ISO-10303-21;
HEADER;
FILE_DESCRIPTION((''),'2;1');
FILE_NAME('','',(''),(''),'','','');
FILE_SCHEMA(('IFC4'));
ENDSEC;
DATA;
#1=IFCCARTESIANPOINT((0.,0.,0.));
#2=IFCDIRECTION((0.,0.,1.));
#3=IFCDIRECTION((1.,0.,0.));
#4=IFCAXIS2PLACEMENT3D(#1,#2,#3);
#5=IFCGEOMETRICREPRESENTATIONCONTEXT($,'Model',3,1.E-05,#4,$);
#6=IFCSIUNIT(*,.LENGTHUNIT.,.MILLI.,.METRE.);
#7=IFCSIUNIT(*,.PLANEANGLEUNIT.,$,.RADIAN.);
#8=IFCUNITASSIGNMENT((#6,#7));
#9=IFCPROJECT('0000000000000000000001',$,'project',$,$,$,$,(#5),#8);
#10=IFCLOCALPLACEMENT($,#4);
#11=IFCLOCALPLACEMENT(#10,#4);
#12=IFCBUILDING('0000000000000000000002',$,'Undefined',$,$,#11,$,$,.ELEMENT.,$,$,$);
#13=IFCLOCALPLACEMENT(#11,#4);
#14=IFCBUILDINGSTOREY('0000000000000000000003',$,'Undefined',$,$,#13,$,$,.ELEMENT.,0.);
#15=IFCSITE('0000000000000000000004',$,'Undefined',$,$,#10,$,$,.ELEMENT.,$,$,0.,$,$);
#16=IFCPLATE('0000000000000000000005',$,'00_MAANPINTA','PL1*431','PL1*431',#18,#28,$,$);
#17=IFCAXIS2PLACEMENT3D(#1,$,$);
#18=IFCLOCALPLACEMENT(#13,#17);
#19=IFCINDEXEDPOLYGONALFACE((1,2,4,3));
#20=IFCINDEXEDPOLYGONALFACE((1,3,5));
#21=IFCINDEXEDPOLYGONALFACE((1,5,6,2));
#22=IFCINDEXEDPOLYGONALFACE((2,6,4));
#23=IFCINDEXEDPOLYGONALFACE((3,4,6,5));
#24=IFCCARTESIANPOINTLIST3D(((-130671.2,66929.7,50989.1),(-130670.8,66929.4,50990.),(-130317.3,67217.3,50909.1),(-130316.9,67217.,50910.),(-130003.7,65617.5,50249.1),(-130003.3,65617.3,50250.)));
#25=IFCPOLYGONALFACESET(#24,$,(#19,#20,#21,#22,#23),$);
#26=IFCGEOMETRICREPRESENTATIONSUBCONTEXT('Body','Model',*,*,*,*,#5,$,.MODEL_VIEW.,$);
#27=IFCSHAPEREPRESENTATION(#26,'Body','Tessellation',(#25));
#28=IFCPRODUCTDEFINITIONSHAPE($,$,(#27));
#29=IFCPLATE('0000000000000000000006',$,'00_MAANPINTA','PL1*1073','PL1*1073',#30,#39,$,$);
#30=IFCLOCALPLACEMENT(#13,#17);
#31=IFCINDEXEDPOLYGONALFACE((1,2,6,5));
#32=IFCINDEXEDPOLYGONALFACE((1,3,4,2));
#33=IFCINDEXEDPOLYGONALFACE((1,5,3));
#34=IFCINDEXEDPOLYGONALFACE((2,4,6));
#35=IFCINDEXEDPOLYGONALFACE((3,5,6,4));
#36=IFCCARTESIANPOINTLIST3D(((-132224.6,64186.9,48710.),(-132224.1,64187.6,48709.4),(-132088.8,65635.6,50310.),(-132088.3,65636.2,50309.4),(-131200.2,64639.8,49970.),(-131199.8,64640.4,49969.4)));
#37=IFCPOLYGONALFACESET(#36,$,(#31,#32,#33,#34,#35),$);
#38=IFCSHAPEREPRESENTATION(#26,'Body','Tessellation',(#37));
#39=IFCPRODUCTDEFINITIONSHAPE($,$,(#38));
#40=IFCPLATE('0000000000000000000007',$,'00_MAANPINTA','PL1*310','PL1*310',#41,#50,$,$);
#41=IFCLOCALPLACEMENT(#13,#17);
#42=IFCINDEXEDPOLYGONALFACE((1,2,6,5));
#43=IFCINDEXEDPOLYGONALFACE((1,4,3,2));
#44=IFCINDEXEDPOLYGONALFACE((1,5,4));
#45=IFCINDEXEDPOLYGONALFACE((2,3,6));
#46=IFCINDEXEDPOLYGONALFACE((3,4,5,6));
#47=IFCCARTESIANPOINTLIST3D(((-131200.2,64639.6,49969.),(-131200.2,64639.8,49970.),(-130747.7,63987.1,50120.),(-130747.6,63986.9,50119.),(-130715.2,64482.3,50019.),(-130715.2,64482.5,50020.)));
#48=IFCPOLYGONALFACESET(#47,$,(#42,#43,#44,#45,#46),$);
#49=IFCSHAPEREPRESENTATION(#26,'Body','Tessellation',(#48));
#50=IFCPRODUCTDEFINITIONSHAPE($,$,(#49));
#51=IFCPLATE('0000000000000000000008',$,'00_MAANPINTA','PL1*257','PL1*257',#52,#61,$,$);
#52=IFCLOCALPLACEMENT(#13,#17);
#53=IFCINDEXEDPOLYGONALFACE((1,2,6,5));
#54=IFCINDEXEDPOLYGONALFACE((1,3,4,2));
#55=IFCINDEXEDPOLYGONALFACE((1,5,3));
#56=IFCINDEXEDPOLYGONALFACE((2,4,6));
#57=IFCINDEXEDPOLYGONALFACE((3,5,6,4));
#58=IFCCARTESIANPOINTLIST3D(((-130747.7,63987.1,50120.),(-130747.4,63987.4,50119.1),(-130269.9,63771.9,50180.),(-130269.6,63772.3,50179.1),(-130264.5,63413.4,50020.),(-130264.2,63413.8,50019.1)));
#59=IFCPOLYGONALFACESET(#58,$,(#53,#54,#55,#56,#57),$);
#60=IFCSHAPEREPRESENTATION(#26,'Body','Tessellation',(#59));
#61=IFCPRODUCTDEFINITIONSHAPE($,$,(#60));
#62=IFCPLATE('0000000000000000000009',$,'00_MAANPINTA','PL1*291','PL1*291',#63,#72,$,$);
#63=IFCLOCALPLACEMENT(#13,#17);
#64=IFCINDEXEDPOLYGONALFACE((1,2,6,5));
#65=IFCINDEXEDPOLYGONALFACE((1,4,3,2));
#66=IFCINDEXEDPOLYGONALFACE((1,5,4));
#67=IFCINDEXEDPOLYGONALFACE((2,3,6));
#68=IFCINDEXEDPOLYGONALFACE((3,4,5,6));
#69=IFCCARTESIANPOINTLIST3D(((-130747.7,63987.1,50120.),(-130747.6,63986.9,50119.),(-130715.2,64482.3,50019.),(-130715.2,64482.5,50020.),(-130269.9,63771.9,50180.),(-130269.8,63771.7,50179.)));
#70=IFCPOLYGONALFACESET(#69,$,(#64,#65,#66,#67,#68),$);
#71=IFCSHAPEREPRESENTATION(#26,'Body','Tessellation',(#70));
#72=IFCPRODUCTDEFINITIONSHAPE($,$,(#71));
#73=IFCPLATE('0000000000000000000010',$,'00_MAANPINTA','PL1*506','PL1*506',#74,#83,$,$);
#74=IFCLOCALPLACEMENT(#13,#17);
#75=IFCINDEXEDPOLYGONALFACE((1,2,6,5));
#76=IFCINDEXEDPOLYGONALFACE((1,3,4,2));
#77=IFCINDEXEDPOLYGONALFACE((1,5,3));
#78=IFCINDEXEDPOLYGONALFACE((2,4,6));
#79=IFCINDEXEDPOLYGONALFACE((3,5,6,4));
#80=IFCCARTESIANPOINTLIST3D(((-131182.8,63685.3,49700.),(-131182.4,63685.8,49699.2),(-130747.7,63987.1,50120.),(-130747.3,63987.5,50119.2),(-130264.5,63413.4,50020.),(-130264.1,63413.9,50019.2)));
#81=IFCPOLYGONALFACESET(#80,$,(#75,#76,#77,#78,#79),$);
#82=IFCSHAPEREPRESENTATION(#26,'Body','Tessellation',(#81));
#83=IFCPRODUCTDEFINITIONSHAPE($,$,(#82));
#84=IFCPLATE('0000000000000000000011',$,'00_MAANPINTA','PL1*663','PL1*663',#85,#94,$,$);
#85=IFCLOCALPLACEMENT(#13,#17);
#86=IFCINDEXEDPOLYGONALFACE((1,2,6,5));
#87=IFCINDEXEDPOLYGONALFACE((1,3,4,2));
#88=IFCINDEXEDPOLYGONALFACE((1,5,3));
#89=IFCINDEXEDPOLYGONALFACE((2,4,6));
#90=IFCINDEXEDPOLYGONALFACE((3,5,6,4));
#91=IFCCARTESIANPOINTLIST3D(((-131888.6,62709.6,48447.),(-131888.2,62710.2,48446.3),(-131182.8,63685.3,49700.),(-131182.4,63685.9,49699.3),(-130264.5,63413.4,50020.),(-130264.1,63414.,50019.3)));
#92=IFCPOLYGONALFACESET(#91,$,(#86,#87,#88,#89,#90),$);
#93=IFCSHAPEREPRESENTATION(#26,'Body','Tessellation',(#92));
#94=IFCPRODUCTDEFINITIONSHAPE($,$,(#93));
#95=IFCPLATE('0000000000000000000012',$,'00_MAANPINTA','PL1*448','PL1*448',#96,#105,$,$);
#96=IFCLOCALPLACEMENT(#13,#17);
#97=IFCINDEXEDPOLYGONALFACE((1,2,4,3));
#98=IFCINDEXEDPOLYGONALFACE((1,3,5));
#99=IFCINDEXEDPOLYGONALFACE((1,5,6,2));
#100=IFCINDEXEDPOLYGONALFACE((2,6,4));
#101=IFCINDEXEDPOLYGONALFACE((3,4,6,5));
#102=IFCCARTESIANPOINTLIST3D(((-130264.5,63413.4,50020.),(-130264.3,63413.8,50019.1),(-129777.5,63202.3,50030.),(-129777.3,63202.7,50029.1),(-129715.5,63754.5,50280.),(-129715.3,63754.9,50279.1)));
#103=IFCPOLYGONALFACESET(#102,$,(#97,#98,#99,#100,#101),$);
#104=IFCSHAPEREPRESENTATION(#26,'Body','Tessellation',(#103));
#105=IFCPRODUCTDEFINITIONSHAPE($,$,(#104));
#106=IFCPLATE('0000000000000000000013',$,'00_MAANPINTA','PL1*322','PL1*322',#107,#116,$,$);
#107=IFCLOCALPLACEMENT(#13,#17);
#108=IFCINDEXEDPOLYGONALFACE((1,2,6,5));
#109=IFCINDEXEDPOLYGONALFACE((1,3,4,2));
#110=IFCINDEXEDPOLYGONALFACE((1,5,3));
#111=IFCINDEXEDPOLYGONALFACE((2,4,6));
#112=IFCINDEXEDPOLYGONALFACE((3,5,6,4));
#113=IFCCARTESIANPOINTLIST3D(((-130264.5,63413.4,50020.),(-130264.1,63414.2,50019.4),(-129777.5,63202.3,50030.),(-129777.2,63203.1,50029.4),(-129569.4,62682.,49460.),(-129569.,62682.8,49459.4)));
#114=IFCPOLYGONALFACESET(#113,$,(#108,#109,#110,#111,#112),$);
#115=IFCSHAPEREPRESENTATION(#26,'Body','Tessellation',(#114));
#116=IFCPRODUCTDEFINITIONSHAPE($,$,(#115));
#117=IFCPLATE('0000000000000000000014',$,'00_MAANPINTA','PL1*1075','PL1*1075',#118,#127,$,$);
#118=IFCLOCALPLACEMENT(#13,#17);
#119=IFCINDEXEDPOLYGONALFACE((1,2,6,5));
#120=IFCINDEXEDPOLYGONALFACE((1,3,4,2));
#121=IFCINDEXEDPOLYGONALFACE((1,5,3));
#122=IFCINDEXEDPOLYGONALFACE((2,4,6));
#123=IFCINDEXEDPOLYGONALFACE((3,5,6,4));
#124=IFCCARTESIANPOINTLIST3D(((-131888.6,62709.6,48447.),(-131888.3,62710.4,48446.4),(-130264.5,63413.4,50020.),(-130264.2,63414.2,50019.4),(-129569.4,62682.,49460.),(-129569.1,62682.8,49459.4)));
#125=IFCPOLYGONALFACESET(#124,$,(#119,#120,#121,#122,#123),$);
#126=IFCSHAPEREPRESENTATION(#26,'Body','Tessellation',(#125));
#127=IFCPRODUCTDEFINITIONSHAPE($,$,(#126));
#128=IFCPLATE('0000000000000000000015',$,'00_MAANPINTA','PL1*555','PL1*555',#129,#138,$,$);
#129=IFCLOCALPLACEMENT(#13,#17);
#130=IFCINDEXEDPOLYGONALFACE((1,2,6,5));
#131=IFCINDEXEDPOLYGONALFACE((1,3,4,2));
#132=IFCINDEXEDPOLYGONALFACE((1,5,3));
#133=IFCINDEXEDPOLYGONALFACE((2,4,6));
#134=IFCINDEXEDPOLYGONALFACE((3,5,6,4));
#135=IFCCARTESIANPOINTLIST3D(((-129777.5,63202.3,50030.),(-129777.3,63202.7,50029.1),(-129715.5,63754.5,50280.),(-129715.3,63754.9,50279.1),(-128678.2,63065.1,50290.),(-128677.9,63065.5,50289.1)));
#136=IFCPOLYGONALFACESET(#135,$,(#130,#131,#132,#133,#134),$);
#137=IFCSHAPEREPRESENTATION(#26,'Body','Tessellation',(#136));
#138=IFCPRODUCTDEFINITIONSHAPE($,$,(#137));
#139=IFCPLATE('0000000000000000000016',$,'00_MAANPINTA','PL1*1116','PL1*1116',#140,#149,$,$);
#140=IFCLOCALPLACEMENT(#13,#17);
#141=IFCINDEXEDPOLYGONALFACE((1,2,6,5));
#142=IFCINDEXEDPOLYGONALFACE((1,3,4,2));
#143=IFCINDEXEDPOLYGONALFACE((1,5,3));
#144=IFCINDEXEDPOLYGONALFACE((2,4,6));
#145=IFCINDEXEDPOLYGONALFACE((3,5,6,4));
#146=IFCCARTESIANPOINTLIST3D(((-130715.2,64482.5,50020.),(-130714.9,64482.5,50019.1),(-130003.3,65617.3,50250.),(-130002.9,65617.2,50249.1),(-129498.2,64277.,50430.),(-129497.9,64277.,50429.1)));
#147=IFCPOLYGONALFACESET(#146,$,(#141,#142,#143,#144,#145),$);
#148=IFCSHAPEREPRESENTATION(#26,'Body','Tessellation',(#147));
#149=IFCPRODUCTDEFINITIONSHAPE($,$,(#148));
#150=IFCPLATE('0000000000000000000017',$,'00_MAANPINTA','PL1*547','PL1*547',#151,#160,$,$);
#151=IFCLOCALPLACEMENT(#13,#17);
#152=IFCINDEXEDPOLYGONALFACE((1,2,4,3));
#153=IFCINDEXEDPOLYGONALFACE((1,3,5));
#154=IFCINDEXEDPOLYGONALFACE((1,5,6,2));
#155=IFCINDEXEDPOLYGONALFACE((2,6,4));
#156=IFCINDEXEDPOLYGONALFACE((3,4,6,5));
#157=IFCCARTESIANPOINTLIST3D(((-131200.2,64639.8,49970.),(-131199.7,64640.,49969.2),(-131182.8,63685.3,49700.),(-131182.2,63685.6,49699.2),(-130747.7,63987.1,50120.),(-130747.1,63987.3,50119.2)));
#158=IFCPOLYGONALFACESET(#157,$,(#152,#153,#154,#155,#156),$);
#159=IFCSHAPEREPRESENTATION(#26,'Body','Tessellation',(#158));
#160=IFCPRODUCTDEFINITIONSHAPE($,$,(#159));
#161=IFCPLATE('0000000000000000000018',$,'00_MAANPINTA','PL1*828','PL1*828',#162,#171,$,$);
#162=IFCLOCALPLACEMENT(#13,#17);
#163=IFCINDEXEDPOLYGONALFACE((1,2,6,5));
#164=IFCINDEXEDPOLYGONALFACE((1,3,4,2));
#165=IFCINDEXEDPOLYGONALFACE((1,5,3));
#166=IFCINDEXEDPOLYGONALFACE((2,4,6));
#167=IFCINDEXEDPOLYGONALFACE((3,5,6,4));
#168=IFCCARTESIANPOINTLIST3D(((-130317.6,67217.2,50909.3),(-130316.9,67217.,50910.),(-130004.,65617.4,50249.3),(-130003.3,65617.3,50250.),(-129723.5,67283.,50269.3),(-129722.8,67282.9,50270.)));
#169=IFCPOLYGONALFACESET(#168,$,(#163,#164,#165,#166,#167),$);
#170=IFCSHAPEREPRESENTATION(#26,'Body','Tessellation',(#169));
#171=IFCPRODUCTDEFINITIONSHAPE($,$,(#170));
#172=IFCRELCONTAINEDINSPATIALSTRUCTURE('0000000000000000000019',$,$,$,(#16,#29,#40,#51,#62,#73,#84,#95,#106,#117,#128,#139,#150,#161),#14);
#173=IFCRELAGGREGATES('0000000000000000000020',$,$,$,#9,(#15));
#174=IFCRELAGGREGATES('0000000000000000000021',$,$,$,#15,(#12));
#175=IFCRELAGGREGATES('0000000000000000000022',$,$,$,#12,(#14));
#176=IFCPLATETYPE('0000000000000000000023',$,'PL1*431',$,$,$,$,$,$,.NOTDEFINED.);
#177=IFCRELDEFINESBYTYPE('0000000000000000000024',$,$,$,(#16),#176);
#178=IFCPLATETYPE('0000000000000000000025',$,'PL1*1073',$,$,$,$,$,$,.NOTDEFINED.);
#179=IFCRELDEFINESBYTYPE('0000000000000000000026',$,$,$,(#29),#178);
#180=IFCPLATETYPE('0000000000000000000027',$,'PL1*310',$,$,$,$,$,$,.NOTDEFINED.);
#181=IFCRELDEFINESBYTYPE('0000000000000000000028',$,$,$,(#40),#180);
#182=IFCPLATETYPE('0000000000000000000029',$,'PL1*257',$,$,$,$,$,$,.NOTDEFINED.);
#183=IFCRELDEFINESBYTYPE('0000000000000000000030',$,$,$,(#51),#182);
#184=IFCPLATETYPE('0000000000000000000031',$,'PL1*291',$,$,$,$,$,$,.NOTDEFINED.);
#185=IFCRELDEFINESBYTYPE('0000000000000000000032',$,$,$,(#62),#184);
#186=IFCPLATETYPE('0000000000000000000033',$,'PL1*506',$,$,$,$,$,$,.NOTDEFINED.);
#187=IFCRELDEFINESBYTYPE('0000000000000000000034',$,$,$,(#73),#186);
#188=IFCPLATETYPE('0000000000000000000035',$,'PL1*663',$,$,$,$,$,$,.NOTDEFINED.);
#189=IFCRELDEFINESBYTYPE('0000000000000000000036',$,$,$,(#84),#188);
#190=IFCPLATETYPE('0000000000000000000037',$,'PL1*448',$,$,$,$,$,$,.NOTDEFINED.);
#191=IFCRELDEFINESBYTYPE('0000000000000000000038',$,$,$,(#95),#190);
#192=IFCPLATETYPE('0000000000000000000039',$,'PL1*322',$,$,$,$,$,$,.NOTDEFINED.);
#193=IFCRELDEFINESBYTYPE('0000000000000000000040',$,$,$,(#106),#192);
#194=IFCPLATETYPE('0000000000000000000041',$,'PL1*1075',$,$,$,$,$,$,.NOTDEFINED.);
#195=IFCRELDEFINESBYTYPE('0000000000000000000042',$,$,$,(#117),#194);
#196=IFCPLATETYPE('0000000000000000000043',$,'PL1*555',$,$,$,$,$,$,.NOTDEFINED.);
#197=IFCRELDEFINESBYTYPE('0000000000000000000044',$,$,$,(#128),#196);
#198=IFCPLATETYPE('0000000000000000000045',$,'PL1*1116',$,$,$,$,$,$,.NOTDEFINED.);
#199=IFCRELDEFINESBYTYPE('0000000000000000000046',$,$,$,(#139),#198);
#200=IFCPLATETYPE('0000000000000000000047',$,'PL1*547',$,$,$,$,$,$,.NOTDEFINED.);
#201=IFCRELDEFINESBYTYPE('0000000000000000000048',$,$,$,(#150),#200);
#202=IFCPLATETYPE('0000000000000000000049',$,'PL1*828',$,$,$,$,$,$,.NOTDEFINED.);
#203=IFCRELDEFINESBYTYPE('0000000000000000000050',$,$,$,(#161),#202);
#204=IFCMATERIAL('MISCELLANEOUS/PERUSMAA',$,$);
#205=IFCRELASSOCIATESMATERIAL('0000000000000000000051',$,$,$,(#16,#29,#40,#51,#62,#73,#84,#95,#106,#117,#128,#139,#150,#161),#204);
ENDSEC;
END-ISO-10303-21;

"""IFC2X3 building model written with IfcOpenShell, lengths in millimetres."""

from ifc_helpers import new_model, si_unit, frame, origin_with_axes, place, context, subcontext, project, spatial, polyline, outline, extrude, material, type_object, element, save


model = new_model("IFC2X3")

# Units and contexts
model_context = context("Model", 3, precision=1e-05, world=origin_with_axes())
body_context = subcontext(model_context, "Body", "Model", "MODEL_VIEW")
ifc_project = project(units=[si_unit("LENGTHUNIT", "METRE", prefix="MILLI"), si_unit("PLANEANGLEUNIT", "RADIAN")], contexts=[model_context])

# Site, building, storey
site_placement = place(None, origin_with_axes())
site = spatial("IfcSite", under=ifc_project, at=site_placement, Name="Undefined", CompositionType="ELEMENT", RefElevation=0.0)
building_placement = place(site_placement, origin_with_axes())
building = spatial("IfcBuilding", under=site, at=building_placement, Name="Undefined", CompositionType="ELEMENT")
storey_placement = place(building_placement, origin_with_axes())
storey = spatial("IfcBuildingStorey", under=building, at=storey_placement, Name="Undefined", CompositionType="ELEMENT", Elevation=0.0)

# Plates
ifc_material = material(Name="MISCELLANEOUS/PERUSMAA")
plate_type_1 = type_object("IfcPlateType", Name="PL1*431", PredefinedType="NOTDEFINED")
plate_1_placement = place(storey_placement, frame((-130671.0, 66929.5, 50989.6), z_axis=(-0.419029, 0.27486, -0.865371), x_axis=(0.76432, 0.62126, -0.172774)))
element("IfcPlate", 1, at=plate_1_placement, inside=storey, type_object=plate_type_1, material=ifc_material, Name="00_MAANPINTA", Description="PL1*431", ObjectType="PL1*431", context=body_context, shape_type="SweptSolid", body=[
    extrude(outline(polyline([(0.0, 0.0), (463.0, 0.0), (-177.1, 1638.2), (0.0, 0.0)])), frame((0.0, 0.0, -0.5), z_axis=(0.0, 0.0, 1.0), x_axis=(1.0, 0.0, 0.0)), (0.0, 0.0, 1.0), 1.0),
])
plate_type_2 = type_object("IfcPlateType", Name="PL1*1073", PredefinedType="NOTDEFINED")
plate_2_placement = place(storey_placement, frame((-131200.0, 64640.1, 49969.7), z_axis=(0.474139, 0.632273, -0.612717), x_axis=(-0.607632, -0.268631, -0.747409)))
element("IfcPlate", 2, at=plate_2_placement, inside=storey, type_object=plate_type_2, material=ifc_material, Name="00_MAANPINTA", Description="PL1*1073", ObjectType="PL1*1073", context=body_context, shape_type="SweptSolid", body=[
    extrude(outline(polyline([(0.0, 0.0), (1685.8, 0.0), (18.3, 1377.0), (0.0, 0.0)])), frame((0.0, 0.0, -0.5), z_axis=(0.0, 0.0, 1.0), x_axis=(1.0, 0.0, 0.0)), (0.0, 0.0, 1.0), 1.0),
])
plate_type_3 = type_object("IfcPlateType", Name="PL1*310", PredefinedType="NOTDEFINED")
plate_3_placement = place(storey_placement, frame((-131200.2, 64639.7, 49969.5), z_axis=(0.036068, -0.199997, -0.979132), x_axis=(0.946677, -0.307049, 0.09759)))
element("IfcPlate", 3, at=plate_3_placement, inside=storey, type_object=plate_type_3, material=ifc_material, Name="00_MAANPINTA", Description="PL1*310", ObjectType="PL1*310", context=body_context, shape_type="SweptSolid", body=[
    extrude(outline(polyline([(0.0, 0.0), (512.3, 0.0), (643.5, 489.2), (0.0, 0.0)])), frame((0.0, 0.0, -0.5), z_axis=(0.0, 0.0, 1.0), x_axis=(1.0, 0.0, 0.0)), (0.0, 0.0, 1.0), 1.0),
])
plate_type_4 = type_object("IfcPlateType", Name="PL1*257", PredefinedType="NOTDEFINED")
plate_4_placement = place(storey_placement, frame((-130747.5, 63987.3, 50119.6), z_axis=(0.287099, 0.394059, -0.873093), x_axis=(0.905886, -0.407959, 0.113756)))
element("IfcPlate", 4, at=plate_4_placement, inside=storey, type_object=plate_type_4, material=ifc_material, Name="00_MAANPINTA", Description="PL1*257", ObjectType="PL1*257", context=body_context, shape_type="SweptSolid", body=[
    extrude(outline(polyline([(0.0, 0.0), (527.4, 0.0), (660.4, 369.4), (0.0, 0.0)])), frame((0.0, 0.0, -0.5), z_axis=(0.0, 0.0, 1.0), x_axis=(1.0, 0.0, 0.0)), (0.0, 0.0, 1.0), 1.0),
])
plate_type_5 = type_object("IfcPlateType", Name="PL1*291", PredefinedType="NOTDEFINED")
plate_5_placement = place(storey_placement, frame((-130715.2, 64482.4, 50019.5), z_axis=(0.032982, -0.199824, -0.979277), x_axis=(0.521645, -0.832325, 0.187407)))
element("IfcPlate", 5, at=plate_5_placement, inside=storey, type_object=plate_type_5, material=ifc_material, Name="00_MAANPINTA", Description="PL1*291", ObjectType="PL1*291", context=body_context, shape_type="SweptSolid", body=[
    extrude(outline(polyline([(0.0, 0.0), (853.8, 0.0), (414.2, 291.5), (0.0, 0.0)])), frame((0.0, 0.0, -0.5), z_axis=(0.0, 0.0, 1.0), x_axis=(1.0, 0.0, 0.0)), (0.0, 0.0, 1.0), 1.0),
])
plate_type_6 = type_object("IfcPlateType", Name="PL1*506", PredefinedType="NOTDEFINED")
plate_6_placement = place(storey_placement, frame((-130264.3, 63413.7, 50019.6), z_axis=(0.412116, 0.48196, -0.773223), x_axis=(-0.909442, 0.269246, -0.316894)))
element("IfcPlate", 6, at=plate_6_placement, inside=storey, type_object=plate_type_6, material=ifc_material, Name="00_MAANPINTA", Description="PL1*506", ObjectType="PL1*506", context=body_context, shape_type="SweptSolid", body=[
    extrude(outline(polyline([(0.0, 0.0), (1009.8, 0.0), (562.2, 506.4), (0.0, 0.0)])), frame((0.0, 0.0, -0.5), z_axis=(0.0, 0.0, 1.0), x_axis=(1.0, 0.0, 0.0)), (0.0, 0.0, 1.0), 1.0),
])
plate_type_7 = type_object("IfcPlateType", Name="PL1*663", PredefinedType="NOTDEFINED")
plate_7_placement = place(storey_placement, frame((-131888.4, 62709.9, 48446.7), z_axis=(0.415831, 0.589049, -0.692897), x_axis=(0.406112, 0.561438, 0.721014)))
element("IfcPlate", 7, at=plate_7_placement, inside=storey, type_object=plate_type_7, material=ifc_material, Name="00_MAANPINTA", Description="PL1*663", ObjectType="PL1*663", context=body_context, shape_type="SweptSolid", body=[
    extrude(outline(polyline([(0.0, 0.0), (1737.8, 0.0), (2188.9, 903.5), (0.0, 0.0)])), frame((0.0, 0.0, -0.5), z_axis=(0.0, 0.0, 1.0), x_axis=(1.0, 0.0, 0.0)), (0.0, 0.0, 1.0), 1.0),
])
plate_type_8 = type_object("IfcPlateType", Name="PL1*448", PredefinedType="NOTDEFINED")
plate_8_placement = place(storey_placement, frame((-130264.4, 63413.6, 50019.5), z_axis=(0.186638, 0.387703, -0.902692), x_axis=(0.788014, 0.489632, 0.373223)))
element("IfcPlate", 8, at=plate_8_placement, inside=storey, type_object=plate_type_8, material=ifc_material, Name="00_MAANPINTA", Description="PL1*448", ObjectType="PL1*448", context=body_context, shape_type="SweptSolid", body=[
    extrude(outline(polyline([(0.0, 0.0), (696.6, 0.0), (284.1, 448.4), (0.0, 0.0)])), frame((0.0, 0.0, -0.5), z_axis=(0.0, 0.0, 1.0), x_axis=(1.0, 0.0, 0.0)), (0.0, 0.0, 1.0), 1.0),
])
plate_type_9 = type_object("IfcPlateType", Name="PL1*322", PredefinedType="NOTDEFINED")
plate_9_placement = place(storey_placement, frame((-129569.2, 62682.4, 49459.7), z_axis=(0.338196, 0.753291, -0.564071), x_axis=(-0.602337, 0.633799, 0.485272)))
element("IfcPlate", 9, at=plate_9_placement, inside=storey, type_object=plate_type_9, material=ifc_material, Name="00_MAANPINTA", Description="PL1*322", ObjectType="PL1*322", context=body_context, shape_type="SweptSolid", body=[
    extrude(outline(polyline([(0.0, 0.0), (1154.0, 0.0), (731.7, 321.7), (0.0, 0.0)])), frame((0.0, 0.0, -0.5), z_axis=(0.0, 0.0, 1.0), x_axis=(1.0, 0.0, 0.0)), (0.0, 0.0, 1.0), 1.0),
])
plate_type_10 = type_object("IfcPlateType", Name="PL1*1075", PredefinedType="NOTDEFINED")
plate_10_placement = place(storey_placement, frame((-130264.3, 63413.8, 50019.7), z_axis=(0.278116, 0.736462, -0.616664), x_axis=(0.602337, -0.633799, -0.485272)))
element("IfcPlate", 10, at=plate_10_placement, inside=storey, type_object=plate_type_10, material=ifc_material, Name="00_MAANPINTA", Description="PL1*1075", ObjectType="PL1*1075", context=body_context, shape_type="SweptSolid", body=[
    extrude(outline(polyline([(0.0, 0.0), (1154.0, 0.0), (231.1, 2356.7), (0.0, 0.0)])), frame((0.0, 0.0, -0.5), z_axis=(0.0, 0.0, 1.0), x_axis=(1.0, 0.0, 0.0)), (0.0, 0.0, 1.0), 1.0),
])
plate_type_11 = type_object("IfcPlateType", Name="PL1*555", PredefinedType="NOTDEFINED")
plate_11_placement = place(storey_placement, frame((-129777.4, 63202.5, 50029.6), z_axis=(0.257407, 0.374387, -0.890829), x_axis=(0.101757, 0.906266, 0.410277)))
element("IfcPlate", 11, at=plate_11_placement, inside=storey, type_object=plate_type_11, material=ifc_material, Name="00_MAANPINTA", Description="PL1*555", ObjectType="PL1*555", context=body_context, shape_type="SweptSolid", body=[
    extrude(outline(polyline([(0.0, 0.0), (609.3, 0.0), (94.2, 1134.1), (0.0, 0.0)])), frame((0.0, 0.0, -0.5), z_axis=(0.0, 0.0, 1.0), x_axis=(1.0, 0.0, 0.0)), (0.0, 0.0, 1.0), 1.0),
])
plate_type_12 = type_object("IfcPlateType", Name="PL1*1116", PredefinedType="NOTDEFINED")
plate_12_placement = place(storey_placement, frame((-130003.1, 65617.3, 50249.5), z_axis=(0.318126, -0.007444, -0.948019), x_axis=(0.349873, -0.928461, 0.124697)))
element("IfcPlate", 12, at=plate_12_placement, inside=storey, type_object=plate_type_12, material=ifc_material, Name="00_MAANPINTA", Description="PL1*1116", ObjectType="PL1*1116", context=body_context, shape_type="SweptSolid", body=[
    extrude(outline(polyline([(0.0, 0.0), (1443.5, 0.0), (775.8, 1116.1), (0.0, 0.0)])), frame((0.0, 0.0, -0.5), z_axis=(0.0, 0.0, 1.0), x_axis=(1.0, 0.0, 0.0)), (0.0, 0.0, 1.0), 1.0),
])
plate_type_13 = type_object("IfcPlateType", Name="PL1*547", PredefinedType="NOTDEFINED")
plate_13_placement = place(storey_placement, frame((-130747.4, 63987.2, 50119.6), z_axis=(0.588576, 0.229985, -0.775039), x_axis=(-0.643854, -0.446416, -0.621421)))
element("IfcPlate", 13, at=plate_13_placement, inside=storey, type_object=plate_type_13, material=ifc_material, Name="00_MAANPINTA", Description="PL1*547", ObjectType="PL1*547", context=body_context, shape_type="SweptSolid", body=[
    extrude(outline(polyline([(0.0, 0.0), (675.9, 0.0), (93.2, 802.9), (0.0, 0.0)])), frame((0.0, 0.0, -0.5), z_axis=(0.0, 0.0, 1.0), x_axis=(1.0, 0.0, 0.0)), (0.0, 0.0, 1.0), 1.0),
])
plate_type_14 = type_object("IfcPlateType", Name="PL1*828", PredefinedType="NOTDEFINED")
plate_14_placement = place(storey_placement, frame((-130003.6, 65617.3, 50249.7), z_axis=(-0.733242, 0.131474, -0.667137), x_axis=(-0.178333, 0.909603, 0.375261)))
element("IfcPlate", 14, at=plate_14_placement, inside=storey, type_object=plate_type_14, material=ifc_material, Name="00_MAANPINTA", Description="PL1*828", ObjectType="PL1*828", context=body_context, shape_type="SweptSolid", body=[
    extrude(outline(polyline([(0.0, 0.0), (1758.8, 0.0), (1472.6, 827.6), (0.0, 0.0)])), frame((0.0, 0.0, -0.5), z_axis=(0.0, 0.0, 1.0), x_axis=(1.0, 0.0, 0.0)), (0.0, 0.0, 1.0), 1.0),
])

save(model, "model.ifc")
